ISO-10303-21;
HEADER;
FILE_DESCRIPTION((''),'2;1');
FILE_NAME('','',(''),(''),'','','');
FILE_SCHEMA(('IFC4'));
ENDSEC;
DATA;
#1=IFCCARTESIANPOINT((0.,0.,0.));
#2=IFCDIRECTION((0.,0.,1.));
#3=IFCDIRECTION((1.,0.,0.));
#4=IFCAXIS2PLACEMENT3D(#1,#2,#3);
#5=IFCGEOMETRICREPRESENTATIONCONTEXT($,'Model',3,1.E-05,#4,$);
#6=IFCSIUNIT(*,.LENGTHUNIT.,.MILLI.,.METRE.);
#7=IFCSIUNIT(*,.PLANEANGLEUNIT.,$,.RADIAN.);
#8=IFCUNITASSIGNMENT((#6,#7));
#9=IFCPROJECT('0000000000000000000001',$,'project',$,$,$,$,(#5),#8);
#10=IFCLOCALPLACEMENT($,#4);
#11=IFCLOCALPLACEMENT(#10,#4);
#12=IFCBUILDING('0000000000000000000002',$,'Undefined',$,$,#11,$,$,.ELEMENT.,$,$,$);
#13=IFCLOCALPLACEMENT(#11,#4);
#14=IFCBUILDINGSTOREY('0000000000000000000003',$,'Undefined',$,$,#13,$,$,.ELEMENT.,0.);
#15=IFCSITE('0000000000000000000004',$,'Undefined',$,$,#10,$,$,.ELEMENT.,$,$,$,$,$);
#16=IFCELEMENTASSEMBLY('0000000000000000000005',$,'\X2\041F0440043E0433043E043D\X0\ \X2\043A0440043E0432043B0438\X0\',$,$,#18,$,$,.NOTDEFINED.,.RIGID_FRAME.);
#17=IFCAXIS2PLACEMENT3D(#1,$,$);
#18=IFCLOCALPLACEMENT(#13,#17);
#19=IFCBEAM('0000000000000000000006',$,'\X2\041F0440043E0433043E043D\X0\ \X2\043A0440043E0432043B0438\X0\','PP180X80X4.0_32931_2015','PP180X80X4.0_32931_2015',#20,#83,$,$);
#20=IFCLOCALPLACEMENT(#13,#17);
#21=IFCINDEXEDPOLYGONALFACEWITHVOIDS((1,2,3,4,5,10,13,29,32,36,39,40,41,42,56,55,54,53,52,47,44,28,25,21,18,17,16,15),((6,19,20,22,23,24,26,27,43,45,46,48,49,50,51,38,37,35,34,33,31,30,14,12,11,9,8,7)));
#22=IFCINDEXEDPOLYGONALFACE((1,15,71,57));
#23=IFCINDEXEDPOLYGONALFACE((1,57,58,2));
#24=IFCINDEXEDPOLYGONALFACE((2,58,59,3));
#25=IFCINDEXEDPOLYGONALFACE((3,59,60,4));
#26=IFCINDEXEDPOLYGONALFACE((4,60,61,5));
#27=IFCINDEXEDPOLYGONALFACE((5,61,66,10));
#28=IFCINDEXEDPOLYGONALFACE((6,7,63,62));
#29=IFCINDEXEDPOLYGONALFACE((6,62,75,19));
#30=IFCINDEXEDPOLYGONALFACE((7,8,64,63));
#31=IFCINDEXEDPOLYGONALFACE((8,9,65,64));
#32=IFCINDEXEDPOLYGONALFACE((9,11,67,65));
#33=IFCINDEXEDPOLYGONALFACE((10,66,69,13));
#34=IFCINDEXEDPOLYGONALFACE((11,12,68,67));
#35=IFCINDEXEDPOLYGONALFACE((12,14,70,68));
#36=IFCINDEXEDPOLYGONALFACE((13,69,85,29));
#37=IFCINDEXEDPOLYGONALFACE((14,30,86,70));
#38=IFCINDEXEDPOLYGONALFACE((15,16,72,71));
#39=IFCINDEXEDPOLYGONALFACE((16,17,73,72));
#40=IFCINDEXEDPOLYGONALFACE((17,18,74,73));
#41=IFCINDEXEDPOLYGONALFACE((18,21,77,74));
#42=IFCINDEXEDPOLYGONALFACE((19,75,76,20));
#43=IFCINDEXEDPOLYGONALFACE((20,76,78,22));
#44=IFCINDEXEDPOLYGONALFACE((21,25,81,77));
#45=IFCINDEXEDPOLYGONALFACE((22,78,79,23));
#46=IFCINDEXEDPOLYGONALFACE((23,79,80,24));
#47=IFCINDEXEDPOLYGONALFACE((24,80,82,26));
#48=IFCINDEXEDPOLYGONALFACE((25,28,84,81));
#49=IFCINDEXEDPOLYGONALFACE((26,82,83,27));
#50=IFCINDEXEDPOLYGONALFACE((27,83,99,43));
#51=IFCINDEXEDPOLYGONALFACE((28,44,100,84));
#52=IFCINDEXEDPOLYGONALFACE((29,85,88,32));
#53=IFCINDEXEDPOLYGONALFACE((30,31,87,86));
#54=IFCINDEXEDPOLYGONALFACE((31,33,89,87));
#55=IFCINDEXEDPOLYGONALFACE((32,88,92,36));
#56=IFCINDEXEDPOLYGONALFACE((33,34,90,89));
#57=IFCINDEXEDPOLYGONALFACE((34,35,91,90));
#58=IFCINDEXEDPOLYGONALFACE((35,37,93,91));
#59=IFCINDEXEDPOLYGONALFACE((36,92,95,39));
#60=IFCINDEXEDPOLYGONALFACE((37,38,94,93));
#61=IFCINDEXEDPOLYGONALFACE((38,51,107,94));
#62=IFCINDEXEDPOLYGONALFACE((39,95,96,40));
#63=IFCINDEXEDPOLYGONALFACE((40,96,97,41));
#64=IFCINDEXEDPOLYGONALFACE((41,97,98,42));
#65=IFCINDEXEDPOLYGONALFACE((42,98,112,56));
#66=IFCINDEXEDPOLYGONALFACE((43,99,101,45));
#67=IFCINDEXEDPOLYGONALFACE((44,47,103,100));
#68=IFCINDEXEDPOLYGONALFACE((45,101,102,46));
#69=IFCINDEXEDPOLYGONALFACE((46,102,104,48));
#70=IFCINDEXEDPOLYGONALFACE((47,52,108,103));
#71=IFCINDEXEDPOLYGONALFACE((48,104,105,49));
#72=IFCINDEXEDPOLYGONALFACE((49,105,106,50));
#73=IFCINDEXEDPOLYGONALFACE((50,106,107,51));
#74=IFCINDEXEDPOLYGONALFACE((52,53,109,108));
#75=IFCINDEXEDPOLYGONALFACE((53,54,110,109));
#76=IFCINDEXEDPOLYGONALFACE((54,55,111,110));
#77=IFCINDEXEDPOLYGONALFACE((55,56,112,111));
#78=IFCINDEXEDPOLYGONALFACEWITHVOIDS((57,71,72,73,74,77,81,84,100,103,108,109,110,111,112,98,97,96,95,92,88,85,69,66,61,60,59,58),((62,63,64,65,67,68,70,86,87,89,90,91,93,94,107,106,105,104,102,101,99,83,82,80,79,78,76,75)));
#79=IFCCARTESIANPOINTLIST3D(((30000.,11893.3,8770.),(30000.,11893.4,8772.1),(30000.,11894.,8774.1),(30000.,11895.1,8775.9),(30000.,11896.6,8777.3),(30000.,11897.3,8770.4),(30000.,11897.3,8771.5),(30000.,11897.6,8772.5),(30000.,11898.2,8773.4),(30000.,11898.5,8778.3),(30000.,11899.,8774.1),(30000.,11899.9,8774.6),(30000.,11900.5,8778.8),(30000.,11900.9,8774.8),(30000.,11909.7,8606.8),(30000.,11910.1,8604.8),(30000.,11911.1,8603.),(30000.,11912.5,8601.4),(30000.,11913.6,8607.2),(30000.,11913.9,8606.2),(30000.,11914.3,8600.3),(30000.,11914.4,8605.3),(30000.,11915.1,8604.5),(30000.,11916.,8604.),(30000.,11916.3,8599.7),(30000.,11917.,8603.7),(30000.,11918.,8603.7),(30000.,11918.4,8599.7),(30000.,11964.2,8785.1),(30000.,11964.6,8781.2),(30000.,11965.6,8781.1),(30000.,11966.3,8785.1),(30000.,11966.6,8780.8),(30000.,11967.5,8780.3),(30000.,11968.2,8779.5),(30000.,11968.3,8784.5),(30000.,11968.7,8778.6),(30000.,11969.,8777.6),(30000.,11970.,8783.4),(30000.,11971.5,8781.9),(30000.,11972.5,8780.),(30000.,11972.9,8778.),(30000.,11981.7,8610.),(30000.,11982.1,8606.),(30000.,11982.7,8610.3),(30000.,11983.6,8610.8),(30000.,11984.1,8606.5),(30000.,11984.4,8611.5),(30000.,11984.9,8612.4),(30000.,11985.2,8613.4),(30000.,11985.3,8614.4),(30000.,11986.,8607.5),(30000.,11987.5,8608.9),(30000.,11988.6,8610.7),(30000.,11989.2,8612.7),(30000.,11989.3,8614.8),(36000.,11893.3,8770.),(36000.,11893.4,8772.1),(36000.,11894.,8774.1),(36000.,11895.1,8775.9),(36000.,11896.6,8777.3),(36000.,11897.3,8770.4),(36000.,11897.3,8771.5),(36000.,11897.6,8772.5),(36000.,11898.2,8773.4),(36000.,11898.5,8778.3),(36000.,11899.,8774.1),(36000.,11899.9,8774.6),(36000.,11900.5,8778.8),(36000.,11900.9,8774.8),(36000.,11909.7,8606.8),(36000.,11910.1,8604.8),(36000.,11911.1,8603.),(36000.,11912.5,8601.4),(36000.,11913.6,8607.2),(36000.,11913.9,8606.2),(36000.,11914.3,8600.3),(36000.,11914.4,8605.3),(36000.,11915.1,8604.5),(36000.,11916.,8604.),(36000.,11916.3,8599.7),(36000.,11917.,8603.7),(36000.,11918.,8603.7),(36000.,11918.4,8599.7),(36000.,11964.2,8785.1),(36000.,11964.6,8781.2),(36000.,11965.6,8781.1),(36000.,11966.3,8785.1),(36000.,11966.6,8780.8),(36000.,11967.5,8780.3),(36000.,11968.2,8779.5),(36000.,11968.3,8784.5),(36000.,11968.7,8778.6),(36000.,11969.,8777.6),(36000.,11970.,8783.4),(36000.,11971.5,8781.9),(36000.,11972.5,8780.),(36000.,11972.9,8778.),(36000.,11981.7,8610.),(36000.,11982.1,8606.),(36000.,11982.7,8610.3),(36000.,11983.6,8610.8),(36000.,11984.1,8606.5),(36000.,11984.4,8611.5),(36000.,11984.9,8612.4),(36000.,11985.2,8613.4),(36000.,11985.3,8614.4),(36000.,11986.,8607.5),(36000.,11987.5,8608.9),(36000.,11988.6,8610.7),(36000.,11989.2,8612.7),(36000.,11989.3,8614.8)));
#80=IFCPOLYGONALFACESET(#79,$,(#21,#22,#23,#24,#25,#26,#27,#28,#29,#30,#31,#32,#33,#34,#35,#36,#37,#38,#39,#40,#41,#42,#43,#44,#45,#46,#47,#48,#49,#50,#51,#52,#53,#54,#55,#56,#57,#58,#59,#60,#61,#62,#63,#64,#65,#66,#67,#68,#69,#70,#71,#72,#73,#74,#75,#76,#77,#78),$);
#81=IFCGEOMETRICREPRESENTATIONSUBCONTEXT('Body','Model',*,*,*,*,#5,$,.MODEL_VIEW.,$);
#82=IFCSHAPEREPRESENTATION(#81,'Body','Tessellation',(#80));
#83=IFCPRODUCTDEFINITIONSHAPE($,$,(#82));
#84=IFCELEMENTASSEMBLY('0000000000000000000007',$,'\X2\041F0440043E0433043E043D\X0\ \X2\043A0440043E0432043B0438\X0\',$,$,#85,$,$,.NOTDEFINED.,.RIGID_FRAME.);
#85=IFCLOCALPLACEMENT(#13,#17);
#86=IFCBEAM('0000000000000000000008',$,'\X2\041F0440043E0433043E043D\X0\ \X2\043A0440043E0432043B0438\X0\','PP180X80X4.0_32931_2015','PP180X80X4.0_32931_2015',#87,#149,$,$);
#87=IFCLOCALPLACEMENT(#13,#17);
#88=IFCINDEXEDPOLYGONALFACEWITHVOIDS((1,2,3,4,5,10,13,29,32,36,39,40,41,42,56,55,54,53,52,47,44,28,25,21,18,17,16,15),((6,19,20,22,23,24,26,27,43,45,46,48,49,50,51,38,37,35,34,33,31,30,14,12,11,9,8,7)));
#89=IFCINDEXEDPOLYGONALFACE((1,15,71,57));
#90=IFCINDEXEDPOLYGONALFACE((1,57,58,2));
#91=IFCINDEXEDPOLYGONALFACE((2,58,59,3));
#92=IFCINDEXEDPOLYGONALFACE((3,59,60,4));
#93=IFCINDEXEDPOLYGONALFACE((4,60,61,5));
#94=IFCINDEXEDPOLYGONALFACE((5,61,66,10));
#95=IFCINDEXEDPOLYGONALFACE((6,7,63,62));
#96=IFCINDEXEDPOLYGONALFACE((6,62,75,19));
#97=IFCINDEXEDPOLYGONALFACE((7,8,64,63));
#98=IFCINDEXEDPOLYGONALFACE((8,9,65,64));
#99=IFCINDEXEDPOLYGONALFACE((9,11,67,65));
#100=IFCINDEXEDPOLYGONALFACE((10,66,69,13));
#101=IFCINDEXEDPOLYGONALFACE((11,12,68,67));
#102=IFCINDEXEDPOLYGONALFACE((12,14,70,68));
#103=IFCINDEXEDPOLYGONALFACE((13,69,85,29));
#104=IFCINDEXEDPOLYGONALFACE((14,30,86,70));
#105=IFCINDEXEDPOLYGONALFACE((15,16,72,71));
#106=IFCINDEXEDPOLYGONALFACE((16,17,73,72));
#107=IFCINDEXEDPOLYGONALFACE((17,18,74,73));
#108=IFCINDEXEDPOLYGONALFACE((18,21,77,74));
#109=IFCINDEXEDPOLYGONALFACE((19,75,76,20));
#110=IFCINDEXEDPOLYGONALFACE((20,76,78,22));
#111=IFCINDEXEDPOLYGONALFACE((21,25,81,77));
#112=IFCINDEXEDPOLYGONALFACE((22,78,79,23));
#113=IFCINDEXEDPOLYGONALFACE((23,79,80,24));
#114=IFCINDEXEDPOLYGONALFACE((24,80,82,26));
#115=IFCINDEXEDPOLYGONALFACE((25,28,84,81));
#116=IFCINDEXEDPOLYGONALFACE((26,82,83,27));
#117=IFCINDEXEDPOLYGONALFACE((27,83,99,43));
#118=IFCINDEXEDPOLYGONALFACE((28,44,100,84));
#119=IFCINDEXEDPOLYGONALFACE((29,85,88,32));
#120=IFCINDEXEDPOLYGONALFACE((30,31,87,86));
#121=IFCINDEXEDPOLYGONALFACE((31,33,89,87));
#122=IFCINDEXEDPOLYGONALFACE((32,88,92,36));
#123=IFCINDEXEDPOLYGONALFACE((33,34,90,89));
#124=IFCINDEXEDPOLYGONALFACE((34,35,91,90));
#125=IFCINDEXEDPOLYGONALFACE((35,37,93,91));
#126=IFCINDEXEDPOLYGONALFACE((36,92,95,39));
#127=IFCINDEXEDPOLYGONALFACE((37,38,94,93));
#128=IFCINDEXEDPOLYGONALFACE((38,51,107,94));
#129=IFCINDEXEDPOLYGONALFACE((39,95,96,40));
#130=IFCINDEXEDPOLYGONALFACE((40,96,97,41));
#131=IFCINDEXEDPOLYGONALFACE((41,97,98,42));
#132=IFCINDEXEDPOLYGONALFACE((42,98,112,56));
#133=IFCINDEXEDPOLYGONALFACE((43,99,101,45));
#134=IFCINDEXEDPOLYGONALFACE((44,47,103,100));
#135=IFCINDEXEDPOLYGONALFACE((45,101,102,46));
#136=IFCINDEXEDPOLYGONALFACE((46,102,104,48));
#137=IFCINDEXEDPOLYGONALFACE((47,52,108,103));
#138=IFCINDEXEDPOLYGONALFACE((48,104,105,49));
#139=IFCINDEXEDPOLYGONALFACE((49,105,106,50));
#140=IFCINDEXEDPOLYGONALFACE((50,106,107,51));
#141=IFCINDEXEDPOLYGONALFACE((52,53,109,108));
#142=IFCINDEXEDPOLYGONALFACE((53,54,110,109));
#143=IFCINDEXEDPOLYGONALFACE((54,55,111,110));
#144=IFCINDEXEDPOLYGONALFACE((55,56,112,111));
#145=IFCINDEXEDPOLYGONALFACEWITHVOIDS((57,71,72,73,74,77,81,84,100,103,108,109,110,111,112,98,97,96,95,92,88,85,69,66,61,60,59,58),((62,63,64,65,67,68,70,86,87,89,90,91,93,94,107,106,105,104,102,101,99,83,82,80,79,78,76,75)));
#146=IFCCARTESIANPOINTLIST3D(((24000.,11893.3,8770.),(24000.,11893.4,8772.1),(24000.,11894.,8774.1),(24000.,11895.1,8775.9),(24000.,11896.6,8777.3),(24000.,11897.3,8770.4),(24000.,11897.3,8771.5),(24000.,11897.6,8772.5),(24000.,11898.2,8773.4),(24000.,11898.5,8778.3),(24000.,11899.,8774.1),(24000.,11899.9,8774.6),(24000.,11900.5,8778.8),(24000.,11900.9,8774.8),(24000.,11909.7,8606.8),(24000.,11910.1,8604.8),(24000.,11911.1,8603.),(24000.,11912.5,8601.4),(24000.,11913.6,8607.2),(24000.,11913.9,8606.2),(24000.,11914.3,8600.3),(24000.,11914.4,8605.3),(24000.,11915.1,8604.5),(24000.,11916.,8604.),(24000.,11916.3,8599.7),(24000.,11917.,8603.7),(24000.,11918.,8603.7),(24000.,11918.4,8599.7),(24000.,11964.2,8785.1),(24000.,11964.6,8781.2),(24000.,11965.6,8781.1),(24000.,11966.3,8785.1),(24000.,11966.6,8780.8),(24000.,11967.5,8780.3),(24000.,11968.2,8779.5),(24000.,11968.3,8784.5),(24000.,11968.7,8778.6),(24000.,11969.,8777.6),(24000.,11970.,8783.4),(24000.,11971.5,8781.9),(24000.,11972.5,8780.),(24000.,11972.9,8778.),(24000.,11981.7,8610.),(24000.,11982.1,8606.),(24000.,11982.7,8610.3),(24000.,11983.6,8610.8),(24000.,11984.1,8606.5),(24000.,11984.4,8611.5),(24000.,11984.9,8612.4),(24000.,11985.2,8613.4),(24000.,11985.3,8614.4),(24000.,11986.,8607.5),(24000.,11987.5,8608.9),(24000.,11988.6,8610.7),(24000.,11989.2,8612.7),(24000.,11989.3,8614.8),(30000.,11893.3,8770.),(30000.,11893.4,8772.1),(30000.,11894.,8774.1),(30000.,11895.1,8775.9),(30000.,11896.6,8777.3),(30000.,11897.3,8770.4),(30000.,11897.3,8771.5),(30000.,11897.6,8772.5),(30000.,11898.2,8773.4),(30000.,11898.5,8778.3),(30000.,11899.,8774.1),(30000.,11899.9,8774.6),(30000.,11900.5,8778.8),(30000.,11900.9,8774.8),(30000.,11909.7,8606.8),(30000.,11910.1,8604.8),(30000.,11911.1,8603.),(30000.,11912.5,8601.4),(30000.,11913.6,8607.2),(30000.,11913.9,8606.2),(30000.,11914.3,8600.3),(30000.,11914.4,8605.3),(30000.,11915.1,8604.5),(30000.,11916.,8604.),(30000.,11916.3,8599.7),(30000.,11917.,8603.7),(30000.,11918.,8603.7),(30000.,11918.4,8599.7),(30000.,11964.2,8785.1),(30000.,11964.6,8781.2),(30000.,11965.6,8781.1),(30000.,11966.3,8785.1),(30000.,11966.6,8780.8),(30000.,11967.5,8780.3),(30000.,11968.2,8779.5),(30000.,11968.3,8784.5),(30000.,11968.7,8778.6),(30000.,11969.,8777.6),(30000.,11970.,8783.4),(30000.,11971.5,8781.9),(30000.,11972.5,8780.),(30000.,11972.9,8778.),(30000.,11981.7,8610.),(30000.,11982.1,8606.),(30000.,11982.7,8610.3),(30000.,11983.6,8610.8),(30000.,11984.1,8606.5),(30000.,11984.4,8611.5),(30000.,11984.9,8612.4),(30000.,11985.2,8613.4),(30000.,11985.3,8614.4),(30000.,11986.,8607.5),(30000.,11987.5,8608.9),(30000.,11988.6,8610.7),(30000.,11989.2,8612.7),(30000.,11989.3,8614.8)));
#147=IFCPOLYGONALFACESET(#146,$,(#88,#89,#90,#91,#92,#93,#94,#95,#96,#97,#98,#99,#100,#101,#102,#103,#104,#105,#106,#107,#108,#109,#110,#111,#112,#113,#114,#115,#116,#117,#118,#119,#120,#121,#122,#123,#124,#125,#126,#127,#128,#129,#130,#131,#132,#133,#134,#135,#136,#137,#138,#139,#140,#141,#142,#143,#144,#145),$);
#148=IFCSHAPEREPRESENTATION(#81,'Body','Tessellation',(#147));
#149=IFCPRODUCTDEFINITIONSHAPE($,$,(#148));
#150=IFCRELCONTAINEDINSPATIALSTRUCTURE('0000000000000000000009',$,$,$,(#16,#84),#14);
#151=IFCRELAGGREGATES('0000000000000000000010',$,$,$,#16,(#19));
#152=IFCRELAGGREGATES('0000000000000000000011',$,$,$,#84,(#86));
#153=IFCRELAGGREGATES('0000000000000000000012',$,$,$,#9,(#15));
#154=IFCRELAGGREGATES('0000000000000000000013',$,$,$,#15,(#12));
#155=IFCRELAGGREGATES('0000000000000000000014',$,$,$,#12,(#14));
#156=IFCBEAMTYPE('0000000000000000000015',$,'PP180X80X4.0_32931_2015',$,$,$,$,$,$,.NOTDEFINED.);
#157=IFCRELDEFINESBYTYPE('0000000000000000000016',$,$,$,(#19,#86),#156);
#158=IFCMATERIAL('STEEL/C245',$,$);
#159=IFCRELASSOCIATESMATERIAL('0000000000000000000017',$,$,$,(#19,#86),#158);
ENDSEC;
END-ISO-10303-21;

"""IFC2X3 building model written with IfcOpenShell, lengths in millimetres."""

from ifc_helpers import new_model, si_unit, frame, origin_with_axes, origin_2d_with_axis, place, context, subcontext, project, spatial, hollow_rectangle, extrude, material, type_object, element, aggregate, save


model = new_model("IFC2X3")

# Units and contexts
model_context = context("Model", 3, precision=1e-05, world=origin_with_axes())
body_context = subcontext(model_context, "Body", "Model", "MODEL_VIEW")
ifc_project = project(units=[si_unit("LENGTHUNIT", "METRE", prefix="MILLI"), si_unit("PLANEANGLEUNIT", "RADIAN")], contexts=[model_context])

# Site, building, storey
site_placement = place(None, origin_with_axes())
site = spatial("IfcSite", under=ifc_project, at=site_placement, Name="Undefined", CompositionType="ELEMENT")
building_placement = place(site_placement, origin_with_axes())
building = spatial("IfcBuilding", under=site, at=building_placement, Name="Undefined", CompositionType="ELEMENT")
storey_placement = place(building_placement, origin_with_axes())
storey = spatial("IfcBuildingStorey", under=building, at=storey_placement, Name="Undefined", CompositionType="ELEMENT", Elevation=0.0)

# Element assemblies, beams
ifc_material_1 = material(Name="STEEL/C245")
assembly_1_placement = place(storey_placement, origin_with_axes())
assembly_1 = element("IfcElementAssembly", 1, at=assembly_1_placement, inside=storey, Name="Прогон кровли", AssemblyPlace="NOTDEFINED", PredefinedType="RIGID_FRAME")
beam_type_1 = type_object("IfcBeamType", Name="PP180X80X4.0_32931_2015", PredefinedType="NOTDEFINED")
beam_1_placement = place(assembly_1_placement, frame((30000.0, 11941.3, 8692.4), z_axis=(0.0, -0.099504, 0.995037), x_axis=(1.0, 0.0, 0.0)))
beam_1 = element("IfcBeam", 2, at=beam_1_placement, type_object=beam_type_1, material=ifc_material_1, Name="Прогон кровли", Description="PP180X80X4.0_32931_2015", ObjectType="PP180X80X4.0_32931_2015", context=body_context, shape_type="SweptSolid", body=[
    extrude(hollow_rectangle(XDim=80.0, YDim=180.0, WallThickness=4.0, InnerFilletRadius=4.0, OuterFilletRadius=8.0, at=origin_2d_with_axis()), frame((6000.0, 0.0, 0.0), z_axis=(-1.0, 0.0, 0.0), x_axis=(0.0, -1.0, 0.0)), (0.0, 0.0, 1.0), 6000.0),
])
aggregate(assembly_1, [beam_1])
assembly_2_placement = place(storey_placement, origin_with_axes())
assembly_2 = element("IfcElementAssembly", 3, at=assembly_2_placement, inside=storey, Name="Прогон кровли", AssemblyPlace="NOTDEFINED", PredefinedType="RIGID_FRAME")
beam_2_placement = place(assembly_2_placement, frame((24000.0, 11941.3, 8692.4), z_axis=(0.0, -0.099504, 0.995037), x_axis=(1.0, 0.0, 0.0)))
beam_2 = element("IfcBeam", 4, at=beam_2_placement, type_object=beam_type_1, material=ifc_material_1, Name="Прогон кровли", Description="PP180X80X4.0_32931_2015", ObjectType="PP180X80X4.0_32931_2015", context=body_context, shape_type="SweptSolid", body=[
    extrude(hollow_rectangle(XDim=80.0, YDim=180.0, WallThickness=4.0, InnerFilletRadius=4.0, OuterFilletRadius=8.0, at=origin_2d_with_axis()), frame((6000.0, 0.0, 0.0), z_axis=(-1.0, 0.0, 0.0), x_axis=(0.0, -1.0, 0.0)), (0.0, 0.0, 1.0), 6000.0),
])
aggregate(assembly_2, [beam_2])

save(model, "model.ifc")
